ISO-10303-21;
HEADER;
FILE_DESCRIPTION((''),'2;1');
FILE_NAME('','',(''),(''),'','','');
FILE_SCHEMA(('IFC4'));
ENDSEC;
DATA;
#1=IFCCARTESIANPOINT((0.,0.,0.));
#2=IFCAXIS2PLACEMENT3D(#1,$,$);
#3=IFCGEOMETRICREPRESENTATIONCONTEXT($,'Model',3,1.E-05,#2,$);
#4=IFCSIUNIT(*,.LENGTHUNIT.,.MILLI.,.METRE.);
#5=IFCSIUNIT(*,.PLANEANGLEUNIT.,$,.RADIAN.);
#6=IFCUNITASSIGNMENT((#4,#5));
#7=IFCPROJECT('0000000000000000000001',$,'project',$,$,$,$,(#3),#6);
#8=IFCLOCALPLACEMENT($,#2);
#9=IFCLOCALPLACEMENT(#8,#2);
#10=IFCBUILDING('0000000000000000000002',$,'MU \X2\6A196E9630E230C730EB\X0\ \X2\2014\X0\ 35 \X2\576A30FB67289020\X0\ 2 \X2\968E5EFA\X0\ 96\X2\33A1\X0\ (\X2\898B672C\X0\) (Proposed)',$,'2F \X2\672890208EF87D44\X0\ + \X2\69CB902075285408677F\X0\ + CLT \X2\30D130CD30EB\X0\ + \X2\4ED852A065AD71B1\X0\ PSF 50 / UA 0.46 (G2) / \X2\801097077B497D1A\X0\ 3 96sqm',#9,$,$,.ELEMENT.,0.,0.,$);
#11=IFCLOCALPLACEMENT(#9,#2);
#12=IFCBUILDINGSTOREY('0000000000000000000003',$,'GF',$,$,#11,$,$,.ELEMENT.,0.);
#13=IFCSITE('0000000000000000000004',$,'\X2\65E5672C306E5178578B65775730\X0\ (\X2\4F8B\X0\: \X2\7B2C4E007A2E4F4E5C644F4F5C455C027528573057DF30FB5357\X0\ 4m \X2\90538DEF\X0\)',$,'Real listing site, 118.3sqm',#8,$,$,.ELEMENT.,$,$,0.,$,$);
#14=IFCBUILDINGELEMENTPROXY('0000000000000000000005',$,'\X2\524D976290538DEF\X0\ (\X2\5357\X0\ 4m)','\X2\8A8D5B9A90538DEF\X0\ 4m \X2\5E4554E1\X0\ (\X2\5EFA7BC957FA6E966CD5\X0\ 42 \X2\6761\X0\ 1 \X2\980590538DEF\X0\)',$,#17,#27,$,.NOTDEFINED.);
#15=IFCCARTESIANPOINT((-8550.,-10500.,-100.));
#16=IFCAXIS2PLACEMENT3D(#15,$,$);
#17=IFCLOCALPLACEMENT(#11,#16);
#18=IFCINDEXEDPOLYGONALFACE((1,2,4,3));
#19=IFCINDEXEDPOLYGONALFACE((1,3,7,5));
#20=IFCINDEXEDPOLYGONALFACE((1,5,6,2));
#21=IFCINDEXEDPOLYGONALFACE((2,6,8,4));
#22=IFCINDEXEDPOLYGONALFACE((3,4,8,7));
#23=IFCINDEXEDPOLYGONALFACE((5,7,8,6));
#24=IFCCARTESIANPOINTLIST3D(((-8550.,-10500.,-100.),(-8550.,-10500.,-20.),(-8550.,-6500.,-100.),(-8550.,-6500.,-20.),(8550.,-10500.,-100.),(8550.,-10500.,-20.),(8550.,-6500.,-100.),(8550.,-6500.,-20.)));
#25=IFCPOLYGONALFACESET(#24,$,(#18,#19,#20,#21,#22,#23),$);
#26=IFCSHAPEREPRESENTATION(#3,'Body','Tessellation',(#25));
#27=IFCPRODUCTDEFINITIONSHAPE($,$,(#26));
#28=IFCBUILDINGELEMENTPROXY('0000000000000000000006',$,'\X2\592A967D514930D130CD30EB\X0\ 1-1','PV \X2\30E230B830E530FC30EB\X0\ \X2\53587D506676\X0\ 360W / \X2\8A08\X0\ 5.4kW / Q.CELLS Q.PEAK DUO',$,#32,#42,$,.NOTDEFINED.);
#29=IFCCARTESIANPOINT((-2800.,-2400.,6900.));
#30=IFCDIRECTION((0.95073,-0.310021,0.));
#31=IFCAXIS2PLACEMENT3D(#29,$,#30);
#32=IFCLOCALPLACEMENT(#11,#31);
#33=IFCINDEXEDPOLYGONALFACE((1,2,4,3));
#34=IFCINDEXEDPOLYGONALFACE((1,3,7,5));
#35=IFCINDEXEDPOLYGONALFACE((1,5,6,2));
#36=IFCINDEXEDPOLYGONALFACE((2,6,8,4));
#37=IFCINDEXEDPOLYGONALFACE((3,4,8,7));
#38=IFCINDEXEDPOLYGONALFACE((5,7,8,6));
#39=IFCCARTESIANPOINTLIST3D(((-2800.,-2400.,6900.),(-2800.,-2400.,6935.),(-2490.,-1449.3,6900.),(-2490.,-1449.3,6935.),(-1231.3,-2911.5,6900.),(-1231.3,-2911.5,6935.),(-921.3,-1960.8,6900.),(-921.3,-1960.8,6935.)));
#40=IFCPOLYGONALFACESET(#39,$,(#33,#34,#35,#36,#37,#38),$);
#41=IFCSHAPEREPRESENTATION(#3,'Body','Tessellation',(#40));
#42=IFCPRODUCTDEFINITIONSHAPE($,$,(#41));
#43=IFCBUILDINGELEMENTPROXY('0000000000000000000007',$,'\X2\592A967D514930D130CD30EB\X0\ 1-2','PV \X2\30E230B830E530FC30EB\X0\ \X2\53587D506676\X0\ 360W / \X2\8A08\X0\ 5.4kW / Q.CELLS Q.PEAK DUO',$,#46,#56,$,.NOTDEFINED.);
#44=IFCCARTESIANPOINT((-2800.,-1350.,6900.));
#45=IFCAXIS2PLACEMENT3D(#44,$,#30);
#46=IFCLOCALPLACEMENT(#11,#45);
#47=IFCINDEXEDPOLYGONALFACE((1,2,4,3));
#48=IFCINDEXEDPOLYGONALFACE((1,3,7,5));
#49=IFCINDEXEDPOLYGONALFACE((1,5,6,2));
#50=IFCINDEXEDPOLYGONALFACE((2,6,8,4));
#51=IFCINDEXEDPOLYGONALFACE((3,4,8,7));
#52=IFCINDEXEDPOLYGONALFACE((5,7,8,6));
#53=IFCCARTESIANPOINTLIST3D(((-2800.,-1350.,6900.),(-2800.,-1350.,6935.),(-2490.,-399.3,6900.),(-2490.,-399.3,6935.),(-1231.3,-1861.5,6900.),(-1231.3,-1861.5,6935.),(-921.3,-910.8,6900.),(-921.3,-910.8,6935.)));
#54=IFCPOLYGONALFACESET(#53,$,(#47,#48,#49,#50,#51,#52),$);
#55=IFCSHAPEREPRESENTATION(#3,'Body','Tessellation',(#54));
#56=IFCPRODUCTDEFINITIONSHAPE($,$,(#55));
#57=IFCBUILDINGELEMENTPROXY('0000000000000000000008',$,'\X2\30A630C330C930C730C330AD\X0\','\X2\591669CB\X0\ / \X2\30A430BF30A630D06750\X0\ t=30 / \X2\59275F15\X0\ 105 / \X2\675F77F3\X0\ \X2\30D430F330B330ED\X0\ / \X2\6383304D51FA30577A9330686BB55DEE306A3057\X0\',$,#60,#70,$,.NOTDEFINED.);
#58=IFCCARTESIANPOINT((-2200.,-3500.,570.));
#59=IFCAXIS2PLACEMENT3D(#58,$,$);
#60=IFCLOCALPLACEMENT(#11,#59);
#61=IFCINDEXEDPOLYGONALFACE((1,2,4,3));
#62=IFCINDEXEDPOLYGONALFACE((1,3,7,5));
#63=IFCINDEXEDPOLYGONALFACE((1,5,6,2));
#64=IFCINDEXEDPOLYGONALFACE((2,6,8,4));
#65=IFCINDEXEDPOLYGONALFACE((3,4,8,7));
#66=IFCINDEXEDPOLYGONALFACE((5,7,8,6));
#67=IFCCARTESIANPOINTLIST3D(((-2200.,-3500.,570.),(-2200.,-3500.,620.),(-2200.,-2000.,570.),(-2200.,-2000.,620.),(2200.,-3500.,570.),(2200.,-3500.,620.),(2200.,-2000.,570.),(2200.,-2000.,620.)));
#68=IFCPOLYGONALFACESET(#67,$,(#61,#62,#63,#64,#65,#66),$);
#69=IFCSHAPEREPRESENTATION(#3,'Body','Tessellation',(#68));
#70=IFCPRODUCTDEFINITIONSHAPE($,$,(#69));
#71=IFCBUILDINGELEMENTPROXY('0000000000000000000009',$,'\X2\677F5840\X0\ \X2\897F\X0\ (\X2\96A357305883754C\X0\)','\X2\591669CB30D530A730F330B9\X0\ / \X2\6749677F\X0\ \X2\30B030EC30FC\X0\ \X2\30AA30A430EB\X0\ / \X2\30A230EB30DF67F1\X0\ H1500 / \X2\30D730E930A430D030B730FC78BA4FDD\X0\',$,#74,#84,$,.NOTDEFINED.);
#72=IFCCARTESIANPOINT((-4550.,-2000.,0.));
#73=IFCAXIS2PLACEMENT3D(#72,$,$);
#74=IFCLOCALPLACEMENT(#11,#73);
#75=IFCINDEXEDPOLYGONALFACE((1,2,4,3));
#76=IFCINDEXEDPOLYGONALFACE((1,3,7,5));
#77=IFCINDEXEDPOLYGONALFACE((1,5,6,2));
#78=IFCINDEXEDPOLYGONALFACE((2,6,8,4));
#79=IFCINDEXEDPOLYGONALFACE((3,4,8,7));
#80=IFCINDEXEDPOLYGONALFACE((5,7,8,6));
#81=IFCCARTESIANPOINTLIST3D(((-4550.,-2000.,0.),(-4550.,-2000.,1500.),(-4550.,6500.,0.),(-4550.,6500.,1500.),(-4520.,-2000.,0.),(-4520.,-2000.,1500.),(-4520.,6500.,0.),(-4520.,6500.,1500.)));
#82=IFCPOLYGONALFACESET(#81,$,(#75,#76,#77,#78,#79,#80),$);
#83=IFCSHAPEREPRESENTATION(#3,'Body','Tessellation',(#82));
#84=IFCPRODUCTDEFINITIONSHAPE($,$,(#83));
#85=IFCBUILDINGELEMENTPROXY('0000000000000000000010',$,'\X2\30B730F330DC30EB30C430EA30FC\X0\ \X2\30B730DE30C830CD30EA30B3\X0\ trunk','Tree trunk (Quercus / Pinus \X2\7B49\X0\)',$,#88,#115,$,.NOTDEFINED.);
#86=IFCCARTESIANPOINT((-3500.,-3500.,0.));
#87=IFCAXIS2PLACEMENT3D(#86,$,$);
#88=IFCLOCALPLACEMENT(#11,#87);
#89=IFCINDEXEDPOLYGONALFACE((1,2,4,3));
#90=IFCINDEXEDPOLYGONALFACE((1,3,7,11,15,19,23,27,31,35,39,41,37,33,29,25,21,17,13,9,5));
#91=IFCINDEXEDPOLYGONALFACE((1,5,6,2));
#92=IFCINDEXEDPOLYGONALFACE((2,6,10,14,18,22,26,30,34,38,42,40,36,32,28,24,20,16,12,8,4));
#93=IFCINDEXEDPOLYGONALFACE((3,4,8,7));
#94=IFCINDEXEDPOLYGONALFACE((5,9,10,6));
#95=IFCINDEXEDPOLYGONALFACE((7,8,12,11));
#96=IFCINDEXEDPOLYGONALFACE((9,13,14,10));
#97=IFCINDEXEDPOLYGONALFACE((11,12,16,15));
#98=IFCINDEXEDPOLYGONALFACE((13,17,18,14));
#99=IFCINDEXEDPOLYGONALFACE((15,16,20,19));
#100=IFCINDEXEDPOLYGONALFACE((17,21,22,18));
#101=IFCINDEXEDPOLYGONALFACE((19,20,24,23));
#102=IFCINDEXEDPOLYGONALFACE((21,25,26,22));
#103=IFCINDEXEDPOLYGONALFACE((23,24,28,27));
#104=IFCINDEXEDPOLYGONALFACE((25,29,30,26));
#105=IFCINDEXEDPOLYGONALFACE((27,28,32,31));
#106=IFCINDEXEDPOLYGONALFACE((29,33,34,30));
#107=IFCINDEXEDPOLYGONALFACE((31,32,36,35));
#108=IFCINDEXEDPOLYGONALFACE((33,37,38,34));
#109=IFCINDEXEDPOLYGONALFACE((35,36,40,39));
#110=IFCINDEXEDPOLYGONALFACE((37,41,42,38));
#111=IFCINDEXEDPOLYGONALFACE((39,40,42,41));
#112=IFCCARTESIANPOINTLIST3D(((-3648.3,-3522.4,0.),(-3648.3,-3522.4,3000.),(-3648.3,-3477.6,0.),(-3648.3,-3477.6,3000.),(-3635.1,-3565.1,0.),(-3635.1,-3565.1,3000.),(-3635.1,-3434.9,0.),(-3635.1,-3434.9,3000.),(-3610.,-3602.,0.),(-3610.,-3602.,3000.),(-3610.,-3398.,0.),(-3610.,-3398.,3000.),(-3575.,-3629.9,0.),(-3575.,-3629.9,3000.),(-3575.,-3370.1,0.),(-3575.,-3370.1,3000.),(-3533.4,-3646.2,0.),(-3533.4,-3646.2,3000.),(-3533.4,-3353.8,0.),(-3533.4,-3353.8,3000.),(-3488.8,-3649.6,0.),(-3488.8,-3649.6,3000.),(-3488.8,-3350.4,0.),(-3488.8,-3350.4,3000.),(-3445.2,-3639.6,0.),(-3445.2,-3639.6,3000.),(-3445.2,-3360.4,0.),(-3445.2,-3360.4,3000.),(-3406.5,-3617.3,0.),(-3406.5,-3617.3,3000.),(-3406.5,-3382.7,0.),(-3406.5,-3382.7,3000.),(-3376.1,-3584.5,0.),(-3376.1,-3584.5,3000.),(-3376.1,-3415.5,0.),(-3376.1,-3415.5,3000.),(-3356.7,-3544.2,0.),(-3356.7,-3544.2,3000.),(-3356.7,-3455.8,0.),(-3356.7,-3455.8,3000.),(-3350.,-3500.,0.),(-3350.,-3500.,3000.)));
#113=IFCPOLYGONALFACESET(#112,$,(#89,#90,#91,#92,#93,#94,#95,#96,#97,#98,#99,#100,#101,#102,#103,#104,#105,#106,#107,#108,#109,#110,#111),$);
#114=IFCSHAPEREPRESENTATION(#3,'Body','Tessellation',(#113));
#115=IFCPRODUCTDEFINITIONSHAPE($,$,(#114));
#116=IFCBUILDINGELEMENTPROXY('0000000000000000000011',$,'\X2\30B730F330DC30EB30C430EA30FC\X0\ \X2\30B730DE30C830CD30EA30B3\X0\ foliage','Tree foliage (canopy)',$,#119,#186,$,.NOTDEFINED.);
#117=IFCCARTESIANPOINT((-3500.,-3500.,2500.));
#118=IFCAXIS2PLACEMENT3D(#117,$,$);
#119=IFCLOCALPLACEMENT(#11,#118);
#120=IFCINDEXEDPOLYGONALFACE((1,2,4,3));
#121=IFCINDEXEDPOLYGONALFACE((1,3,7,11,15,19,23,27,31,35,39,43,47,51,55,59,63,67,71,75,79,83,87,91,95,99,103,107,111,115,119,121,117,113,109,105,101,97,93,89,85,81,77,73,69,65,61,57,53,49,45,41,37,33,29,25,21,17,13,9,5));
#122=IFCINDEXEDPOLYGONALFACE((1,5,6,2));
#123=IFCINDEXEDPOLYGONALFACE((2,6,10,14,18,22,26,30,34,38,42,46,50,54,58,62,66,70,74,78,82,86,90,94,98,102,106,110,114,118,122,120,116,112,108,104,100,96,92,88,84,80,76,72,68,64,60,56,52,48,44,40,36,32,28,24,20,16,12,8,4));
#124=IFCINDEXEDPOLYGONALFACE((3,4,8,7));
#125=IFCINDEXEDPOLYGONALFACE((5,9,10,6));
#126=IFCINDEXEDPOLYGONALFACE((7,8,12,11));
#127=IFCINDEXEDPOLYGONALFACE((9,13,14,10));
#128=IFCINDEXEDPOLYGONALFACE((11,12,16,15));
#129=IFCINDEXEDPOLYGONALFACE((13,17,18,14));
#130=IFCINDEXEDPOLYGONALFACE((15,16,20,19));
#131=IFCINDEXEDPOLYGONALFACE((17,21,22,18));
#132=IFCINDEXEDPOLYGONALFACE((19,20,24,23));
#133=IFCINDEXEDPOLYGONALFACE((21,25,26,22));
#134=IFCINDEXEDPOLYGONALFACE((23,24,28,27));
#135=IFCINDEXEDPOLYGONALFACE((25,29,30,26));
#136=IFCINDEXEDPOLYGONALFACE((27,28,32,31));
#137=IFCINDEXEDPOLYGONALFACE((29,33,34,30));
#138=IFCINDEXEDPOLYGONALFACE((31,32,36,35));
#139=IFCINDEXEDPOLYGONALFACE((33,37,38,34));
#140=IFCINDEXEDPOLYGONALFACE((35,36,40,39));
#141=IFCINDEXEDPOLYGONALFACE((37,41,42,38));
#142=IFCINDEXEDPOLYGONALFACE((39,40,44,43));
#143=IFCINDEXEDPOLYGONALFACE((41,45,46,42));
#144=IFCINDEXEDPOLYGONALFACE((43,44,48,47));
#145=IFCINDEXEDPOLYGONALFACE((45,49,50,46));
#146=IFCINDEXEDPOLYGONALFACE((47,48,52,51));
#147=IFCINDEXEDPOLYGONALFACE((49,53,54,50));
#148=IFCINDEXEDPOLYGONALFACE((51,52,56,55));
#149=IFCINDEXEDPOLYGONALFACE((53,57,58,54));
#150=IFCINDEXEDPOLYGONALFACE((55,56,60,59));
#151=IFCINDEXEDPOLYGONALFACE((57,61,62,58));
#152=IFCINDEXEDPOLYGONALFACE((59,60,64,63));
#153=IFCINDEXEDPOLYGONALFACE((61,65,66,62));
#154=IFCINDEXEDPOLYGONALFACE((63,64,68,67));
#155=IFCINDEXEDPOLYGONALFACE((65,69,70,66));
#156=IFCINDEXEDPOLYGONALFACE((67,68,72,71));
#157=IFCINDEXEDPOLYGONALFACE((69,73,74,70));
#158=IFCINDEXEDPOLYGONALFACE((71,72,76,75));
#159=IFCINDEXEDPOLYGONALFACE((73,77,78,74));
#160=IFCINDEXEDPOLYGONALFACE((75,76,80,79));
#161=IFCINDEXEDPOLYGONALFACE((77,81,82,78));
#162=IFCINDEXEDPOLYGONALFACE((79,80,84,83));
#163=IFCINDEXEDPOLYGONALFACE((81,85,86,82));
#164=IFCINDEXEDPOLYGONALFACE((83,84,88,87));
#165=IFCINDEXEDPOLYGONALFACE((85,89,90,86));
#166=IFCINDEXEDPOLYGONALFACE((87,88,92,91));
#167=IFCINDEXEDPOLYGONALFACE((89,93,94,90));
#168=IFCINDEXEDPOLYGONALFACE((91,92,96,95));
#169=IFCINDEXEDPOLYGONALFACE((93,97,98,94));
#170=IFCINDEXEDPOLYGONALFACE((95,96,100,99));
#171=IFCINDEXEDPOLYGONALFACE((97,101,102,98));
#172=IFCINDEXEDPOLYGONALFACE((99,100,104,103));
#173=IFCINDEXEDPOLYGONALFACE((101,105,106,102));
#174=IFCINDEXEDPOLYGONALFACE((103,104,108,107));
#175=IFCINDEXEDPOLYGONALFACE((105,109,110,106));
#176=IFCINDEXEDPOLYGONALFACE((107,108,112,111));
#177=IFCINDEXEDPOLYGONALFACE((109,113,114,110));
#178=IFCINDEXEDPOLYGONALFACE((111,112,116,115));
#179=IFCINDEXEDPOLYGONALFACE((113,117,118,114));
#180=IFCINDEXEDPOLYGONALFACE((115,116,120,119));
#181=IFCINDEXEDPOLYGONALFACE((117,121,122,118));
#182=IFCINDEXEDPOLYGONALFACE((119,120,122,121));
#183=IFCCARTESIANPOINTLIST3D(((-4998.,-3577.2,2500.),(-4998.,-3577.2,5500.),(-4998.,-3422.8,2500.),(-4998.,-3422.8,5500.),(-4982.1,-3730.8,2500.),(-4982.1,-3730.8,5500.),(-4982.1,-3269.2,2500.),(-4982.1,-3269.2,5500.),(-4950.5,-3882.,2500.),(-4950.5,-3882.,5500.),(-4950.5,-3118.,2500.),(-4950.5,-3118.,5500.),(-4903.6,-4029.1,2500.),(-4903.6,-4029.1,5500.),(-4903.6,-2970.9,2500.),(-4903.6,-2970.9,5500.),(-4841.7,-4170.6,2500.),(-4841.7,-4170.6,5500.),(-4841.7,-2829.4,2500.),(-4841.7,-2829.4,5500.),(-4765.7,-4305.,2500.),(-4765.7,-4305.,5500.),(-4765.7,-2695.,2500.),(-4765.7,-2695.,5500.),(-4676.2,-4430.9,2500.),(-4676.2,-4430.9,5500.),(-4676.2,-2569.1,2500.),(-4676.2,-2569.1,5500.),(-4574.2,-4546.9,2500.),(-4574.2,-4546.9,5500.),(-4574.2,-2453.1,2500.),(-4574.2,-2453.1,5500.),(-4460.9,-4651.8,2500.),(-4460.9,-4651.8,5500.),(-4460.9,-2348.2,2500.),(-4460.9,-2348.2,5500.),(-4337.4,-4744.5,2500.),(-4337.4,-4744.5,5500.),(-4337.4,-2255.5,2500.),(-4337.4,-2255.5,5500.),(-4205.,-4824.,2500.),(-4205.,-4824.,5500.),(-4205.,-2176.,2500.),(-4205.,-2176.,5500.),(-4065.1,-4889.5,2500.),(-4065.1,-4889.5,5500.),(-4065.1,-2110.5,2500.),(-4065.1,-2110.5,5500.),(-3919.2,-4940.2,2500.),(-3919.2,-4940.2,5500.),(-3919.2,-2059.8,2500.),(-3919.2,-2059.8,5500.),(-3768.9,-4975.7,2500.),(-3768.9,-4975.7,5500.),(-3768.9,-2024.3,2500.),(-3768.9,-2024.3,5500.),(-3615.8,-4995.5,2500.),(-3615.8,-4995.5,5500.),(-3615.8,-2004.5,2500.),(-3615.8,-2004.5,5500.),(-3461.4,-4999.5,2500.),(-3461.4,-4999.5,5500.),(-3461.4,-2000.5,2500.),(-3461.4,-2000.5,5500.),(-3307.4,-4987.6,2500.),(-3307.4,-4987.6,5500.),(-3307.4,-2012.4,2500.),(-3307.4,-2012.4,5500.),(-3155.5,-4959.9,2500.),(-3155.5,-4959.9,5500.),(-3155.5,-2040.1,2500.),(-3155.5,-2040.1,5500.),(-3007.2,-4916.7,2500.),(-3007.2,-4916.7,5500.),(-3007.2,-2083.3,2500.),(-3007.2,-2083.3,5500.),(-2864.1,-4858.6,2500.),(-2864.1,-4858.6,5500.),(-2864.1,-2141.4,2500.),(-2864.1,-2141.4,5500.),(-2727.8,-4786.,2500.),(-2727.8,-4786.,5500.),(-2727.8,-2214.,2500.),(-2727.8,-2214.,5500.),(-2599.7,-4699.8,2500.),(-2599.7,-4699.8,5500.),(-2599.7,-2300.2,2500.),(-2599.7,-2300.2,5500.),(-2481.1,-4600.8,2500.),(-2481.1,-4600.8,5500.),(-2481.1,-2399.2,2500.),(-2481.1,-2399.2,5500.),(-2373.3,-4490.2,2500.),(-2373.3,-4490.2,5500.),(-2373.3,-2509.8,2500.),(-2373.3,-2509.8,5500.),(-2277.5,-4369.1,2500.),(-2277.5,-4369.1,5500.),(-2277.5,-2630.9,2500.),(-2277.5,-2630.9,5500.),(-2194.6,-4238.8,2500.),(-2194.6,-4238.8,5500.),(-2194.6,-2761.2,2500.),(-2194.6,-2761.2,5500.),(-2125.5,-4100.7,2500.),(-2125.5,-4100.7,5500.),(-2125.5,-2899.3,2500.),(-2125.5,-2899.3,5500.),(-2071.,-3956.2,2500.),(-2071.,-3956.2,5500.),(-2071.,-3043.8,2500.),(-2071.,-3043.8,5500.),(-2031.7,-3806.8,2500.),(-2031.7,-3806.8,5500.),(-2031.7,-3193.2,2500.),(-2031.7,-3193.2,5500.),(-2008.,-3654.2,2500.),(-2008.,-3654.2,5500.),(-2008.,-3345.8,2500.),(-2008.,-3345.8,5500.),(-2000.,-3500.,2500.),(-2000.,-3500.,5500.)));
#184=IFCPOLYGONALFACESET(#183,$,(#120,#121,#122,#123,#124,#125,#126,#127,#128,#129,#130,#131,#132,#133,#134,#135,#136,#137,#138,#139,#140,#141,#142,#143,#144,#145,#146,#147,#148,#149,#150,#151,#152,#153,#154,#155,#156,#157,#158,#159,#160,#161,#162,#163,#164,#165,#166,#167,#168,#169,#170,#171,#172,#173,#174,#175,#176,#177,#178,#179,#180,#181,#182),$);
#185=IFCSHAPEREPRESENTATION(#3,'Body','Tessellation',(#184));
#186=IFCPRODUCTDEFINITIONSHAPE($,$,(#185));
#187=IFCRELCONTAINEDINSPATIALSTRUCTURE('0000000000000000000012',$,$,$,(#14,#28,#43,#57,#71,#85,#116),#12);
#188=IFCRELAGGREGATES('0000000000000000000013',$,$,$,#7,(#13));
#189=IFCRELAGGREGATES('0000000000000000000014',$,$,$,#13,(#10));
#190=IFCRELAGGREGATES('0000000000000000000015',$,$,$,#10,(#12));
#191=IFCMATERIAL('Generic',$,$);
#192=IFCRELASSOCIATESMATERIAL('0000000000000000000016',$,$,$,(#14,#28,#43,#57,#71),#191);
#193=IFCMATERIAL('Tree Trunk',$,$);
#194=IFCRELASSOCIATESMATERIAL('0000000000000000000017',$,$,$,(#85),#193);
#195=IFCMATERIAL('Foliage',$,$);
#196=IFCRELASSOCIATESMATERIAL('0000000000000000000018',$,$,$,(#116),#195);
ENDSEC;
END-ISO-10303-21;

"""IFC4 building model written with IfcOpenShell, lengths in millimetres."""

from ifc_helpers import new_model, si_unit, frame, frame_2d, origin, origin_2d, place, context, project, spatial, rectangle, circle, extrude, material, element, save


model = new_model("IFC4")

# Units and contexts
model_context = context("Model", 3, precision=1e-05, world=origin())
ifc_project = project(units=[si_unit("LENGTHUNIT", "METRE", prefix="MILLI"), si_unit("PLANEANGLEUNIT", "RADIAN")], contexts=[model_context])

# Site, building, storey
site_placement = place(None, origin())
site = spatial("IfcSite", under=ifc_project, at=site_placement, Name="日本の典型敷地 (例: 第一種低層住居専用地域・南 4m 道路)", ObjectType="Real listing site, 118.3sqm", CompositionType="ELEMENT", RefElevation=0.0)
building_placement = place(site_placement, origin())
building = spatial("IfcBuilding", under=site, at=building_placement, Name="MU 標準モデル — 35 坪・木造 2 階建 96㎡ (見本) (Proposed)", ObjectType="2F 木造軸組 + 構造用合板 + CLT パネル + 付加断熱 PSF 50 / UA 0.46 (G2) / 耐震等級 3 96sqm", CompositionType="ELEMENT", ElevationOfRefHeight=0.0, ElevationOfTerrain=0.0)
storey_placement = place(building_placement, origin())
storey = spatial("IfcBuildingStorey", under=building, at=storey_placement, Name="GF", CompositionType="ELEMENT", Elevation=0.0)

# Shared definitions
ifc_material_1 = material(Name="Generic")

# Building element proxies
proxy_1_placement = place(storey_placement, frame((-8550.0, -10500.0, -100.0)))
element("IfcBuildingElementProxy", 1, at=proxy_1_placement, inside=storey, material=ifc_material_1, Name="前面道路 (南 4m)", Description="認定道路 4m 幅員 (建築基準法 42 条 1 項道路)", PredefinedType="NOTDEFINED", context=model_context, shape_type="SweptSolid", body=[
    extrude(rectangle(XDim=17100.0, YDim=4000.0, at=frame_2d((8550.0, 2000.0))), frame((-8550.0, -10500.0, -100.0)), (0.0, 0.0, 1.0), 80.0),
])
proxy_2_placement = place(storey_placement, frame((-2800.0, -2400.0, 6900.0), x_axis=(0.95073, -0.310021, 0.0)))
element("IfcBuildingElementProxy", 2, at=proxy_2_placement, inside=storey, material=ifc_material_1, Name="太陽光パネル 1-1", Description="PV モジュール 単結晶 360W / 計 5.4kW / Q.CELLS Q.PEAK DUO", PredefinedType="NOTDEFINED", context=model_context, shape_type="SweptSolid", body=[
    extrude(rectangle(XDim=1650.0, YDim=1000.0, at=frame_2d((825.0, 500.0))), frame((-2800.0, -2400.0, 6900.0), x_axis=(0.95073, -0.310021, 0.0)), (0.0, 0.0, 1.0), 35.0),
])
proxy_3_placement = place(storey_placement, frame((-2800.0, -1350.0, 6900.0), x_axis=(0.95073, -0.310021, 0.0)))
element("IfcBuildingElementProxy", 3, at=proxy_3_placement, inside=storey, material=ifc_material_1, Name="太陽光パネル 1-2", Description="PV モジュール 単結晶 360W / 計 5.4kW / Q.CELLS Q.PEAK DUO", PredefinedType="NOTDEFINED", context=model_context, shape_type="SweptSolid", body=[
    extrude(rectangle(XDim=1650.0, YDim=1000.0, at=frame_2d((825.0, 500.0))), frame((-2800.0, -1350.0, 6900.0), x_axis=(0.95073, -0.310021, 0.0)), (0.0, 0.0, 1.0), 35.0),
])
proxy_4_placement = place(storey_placement, frame((-2200.0, -3500.0, 570.0)))
element("IfcBuildingElementProxy", 4, at=proxy_4_placement, inside=storey, material=ifc_material_1, Name="ウッドデッキ", Description="外構 / イタウバ材 t=30 / 大引 105 / 束石 ピンコロ / 掃き出し窓と段差なし", PredefinedType="NOTDEFINED", context=model_context, shape_type="SweptSolid", body=[
    extrude(rectangle(XDim=4400.0, YDim=1500.0, at=frame_2d((2200.0, 750.0))), frame((-2200.0, -3500.0, 570.0)), (0.0, 0.0, 1.0), 50.0),
])
proxy_5_placement = place(storey_placement, frame((-4550.0, -2000.0, 0.0)))
element("IfcBuildingElementProxy", 5, at=proxy_5_placement, inside=storey, material=ifc_material_1, Name="板塀 西 (隣地境界)", Description="外構フェンス / 杉板 グレー オイル / アルミ柱 H1500 / プライバシー確保", PredefinedType="NOTDEFINED", context=model_context, shape_type="SweptSolid", body=[
    extrude(rectangle(XDim=30.0, YDim=8500.0, at=frame_2d((15.0, 4250.0))), frame((-4550.0, -2000.0, 0.0)), (0.0, 0.0, 1.0), 1500.0),
])
ifc_material_2 = material(Name="Tree Trunk")
proxy_6_placement = place(storey_placement, frame((-3500.0, -3500.0, 0.0)))
element("IfcBuildingElementProxy", 6, at=proxy_6_placement, inside=storey, material=ifc_material_2, Name="シンボルツリー シマトネリコ trunk", Description="Tree trunk (Quercus / Pinus 等)", PredefinedType="NOTDEFINED", context=model_context, shape_type="SweptSolid", body=[
    extrude(circle(Radius=150.0, at=origin_2d()), frame((-3500.0, -3500.0, 0.0)), (0.0, 0.0, 1.0), 3000.0),
])
ifc_material_3 = material(Name="Foliage")
proxy_7_placement = place(storey_placement, frame((-3500.0, -3500.0, 2500.0)))
element("IfcBuildingElementProxy", 7, at=proxy_7_placement, inside=storey, material=ifc_material_3, Name="シンボルツリー シマトネリコ foliage", Description="Tree foliage (canopy)", PredefinedType="NOTDEFINED", context=model_context, shape_type="SweptSolid", body=[
    extrude(circle(Radius=1500.0, at=origin_2d()), frame((-3500.0, -3500.0, 2500.0)), (0.0, 0.0, 1.0), 3000.0),
])

save(model, "model.ifc")
